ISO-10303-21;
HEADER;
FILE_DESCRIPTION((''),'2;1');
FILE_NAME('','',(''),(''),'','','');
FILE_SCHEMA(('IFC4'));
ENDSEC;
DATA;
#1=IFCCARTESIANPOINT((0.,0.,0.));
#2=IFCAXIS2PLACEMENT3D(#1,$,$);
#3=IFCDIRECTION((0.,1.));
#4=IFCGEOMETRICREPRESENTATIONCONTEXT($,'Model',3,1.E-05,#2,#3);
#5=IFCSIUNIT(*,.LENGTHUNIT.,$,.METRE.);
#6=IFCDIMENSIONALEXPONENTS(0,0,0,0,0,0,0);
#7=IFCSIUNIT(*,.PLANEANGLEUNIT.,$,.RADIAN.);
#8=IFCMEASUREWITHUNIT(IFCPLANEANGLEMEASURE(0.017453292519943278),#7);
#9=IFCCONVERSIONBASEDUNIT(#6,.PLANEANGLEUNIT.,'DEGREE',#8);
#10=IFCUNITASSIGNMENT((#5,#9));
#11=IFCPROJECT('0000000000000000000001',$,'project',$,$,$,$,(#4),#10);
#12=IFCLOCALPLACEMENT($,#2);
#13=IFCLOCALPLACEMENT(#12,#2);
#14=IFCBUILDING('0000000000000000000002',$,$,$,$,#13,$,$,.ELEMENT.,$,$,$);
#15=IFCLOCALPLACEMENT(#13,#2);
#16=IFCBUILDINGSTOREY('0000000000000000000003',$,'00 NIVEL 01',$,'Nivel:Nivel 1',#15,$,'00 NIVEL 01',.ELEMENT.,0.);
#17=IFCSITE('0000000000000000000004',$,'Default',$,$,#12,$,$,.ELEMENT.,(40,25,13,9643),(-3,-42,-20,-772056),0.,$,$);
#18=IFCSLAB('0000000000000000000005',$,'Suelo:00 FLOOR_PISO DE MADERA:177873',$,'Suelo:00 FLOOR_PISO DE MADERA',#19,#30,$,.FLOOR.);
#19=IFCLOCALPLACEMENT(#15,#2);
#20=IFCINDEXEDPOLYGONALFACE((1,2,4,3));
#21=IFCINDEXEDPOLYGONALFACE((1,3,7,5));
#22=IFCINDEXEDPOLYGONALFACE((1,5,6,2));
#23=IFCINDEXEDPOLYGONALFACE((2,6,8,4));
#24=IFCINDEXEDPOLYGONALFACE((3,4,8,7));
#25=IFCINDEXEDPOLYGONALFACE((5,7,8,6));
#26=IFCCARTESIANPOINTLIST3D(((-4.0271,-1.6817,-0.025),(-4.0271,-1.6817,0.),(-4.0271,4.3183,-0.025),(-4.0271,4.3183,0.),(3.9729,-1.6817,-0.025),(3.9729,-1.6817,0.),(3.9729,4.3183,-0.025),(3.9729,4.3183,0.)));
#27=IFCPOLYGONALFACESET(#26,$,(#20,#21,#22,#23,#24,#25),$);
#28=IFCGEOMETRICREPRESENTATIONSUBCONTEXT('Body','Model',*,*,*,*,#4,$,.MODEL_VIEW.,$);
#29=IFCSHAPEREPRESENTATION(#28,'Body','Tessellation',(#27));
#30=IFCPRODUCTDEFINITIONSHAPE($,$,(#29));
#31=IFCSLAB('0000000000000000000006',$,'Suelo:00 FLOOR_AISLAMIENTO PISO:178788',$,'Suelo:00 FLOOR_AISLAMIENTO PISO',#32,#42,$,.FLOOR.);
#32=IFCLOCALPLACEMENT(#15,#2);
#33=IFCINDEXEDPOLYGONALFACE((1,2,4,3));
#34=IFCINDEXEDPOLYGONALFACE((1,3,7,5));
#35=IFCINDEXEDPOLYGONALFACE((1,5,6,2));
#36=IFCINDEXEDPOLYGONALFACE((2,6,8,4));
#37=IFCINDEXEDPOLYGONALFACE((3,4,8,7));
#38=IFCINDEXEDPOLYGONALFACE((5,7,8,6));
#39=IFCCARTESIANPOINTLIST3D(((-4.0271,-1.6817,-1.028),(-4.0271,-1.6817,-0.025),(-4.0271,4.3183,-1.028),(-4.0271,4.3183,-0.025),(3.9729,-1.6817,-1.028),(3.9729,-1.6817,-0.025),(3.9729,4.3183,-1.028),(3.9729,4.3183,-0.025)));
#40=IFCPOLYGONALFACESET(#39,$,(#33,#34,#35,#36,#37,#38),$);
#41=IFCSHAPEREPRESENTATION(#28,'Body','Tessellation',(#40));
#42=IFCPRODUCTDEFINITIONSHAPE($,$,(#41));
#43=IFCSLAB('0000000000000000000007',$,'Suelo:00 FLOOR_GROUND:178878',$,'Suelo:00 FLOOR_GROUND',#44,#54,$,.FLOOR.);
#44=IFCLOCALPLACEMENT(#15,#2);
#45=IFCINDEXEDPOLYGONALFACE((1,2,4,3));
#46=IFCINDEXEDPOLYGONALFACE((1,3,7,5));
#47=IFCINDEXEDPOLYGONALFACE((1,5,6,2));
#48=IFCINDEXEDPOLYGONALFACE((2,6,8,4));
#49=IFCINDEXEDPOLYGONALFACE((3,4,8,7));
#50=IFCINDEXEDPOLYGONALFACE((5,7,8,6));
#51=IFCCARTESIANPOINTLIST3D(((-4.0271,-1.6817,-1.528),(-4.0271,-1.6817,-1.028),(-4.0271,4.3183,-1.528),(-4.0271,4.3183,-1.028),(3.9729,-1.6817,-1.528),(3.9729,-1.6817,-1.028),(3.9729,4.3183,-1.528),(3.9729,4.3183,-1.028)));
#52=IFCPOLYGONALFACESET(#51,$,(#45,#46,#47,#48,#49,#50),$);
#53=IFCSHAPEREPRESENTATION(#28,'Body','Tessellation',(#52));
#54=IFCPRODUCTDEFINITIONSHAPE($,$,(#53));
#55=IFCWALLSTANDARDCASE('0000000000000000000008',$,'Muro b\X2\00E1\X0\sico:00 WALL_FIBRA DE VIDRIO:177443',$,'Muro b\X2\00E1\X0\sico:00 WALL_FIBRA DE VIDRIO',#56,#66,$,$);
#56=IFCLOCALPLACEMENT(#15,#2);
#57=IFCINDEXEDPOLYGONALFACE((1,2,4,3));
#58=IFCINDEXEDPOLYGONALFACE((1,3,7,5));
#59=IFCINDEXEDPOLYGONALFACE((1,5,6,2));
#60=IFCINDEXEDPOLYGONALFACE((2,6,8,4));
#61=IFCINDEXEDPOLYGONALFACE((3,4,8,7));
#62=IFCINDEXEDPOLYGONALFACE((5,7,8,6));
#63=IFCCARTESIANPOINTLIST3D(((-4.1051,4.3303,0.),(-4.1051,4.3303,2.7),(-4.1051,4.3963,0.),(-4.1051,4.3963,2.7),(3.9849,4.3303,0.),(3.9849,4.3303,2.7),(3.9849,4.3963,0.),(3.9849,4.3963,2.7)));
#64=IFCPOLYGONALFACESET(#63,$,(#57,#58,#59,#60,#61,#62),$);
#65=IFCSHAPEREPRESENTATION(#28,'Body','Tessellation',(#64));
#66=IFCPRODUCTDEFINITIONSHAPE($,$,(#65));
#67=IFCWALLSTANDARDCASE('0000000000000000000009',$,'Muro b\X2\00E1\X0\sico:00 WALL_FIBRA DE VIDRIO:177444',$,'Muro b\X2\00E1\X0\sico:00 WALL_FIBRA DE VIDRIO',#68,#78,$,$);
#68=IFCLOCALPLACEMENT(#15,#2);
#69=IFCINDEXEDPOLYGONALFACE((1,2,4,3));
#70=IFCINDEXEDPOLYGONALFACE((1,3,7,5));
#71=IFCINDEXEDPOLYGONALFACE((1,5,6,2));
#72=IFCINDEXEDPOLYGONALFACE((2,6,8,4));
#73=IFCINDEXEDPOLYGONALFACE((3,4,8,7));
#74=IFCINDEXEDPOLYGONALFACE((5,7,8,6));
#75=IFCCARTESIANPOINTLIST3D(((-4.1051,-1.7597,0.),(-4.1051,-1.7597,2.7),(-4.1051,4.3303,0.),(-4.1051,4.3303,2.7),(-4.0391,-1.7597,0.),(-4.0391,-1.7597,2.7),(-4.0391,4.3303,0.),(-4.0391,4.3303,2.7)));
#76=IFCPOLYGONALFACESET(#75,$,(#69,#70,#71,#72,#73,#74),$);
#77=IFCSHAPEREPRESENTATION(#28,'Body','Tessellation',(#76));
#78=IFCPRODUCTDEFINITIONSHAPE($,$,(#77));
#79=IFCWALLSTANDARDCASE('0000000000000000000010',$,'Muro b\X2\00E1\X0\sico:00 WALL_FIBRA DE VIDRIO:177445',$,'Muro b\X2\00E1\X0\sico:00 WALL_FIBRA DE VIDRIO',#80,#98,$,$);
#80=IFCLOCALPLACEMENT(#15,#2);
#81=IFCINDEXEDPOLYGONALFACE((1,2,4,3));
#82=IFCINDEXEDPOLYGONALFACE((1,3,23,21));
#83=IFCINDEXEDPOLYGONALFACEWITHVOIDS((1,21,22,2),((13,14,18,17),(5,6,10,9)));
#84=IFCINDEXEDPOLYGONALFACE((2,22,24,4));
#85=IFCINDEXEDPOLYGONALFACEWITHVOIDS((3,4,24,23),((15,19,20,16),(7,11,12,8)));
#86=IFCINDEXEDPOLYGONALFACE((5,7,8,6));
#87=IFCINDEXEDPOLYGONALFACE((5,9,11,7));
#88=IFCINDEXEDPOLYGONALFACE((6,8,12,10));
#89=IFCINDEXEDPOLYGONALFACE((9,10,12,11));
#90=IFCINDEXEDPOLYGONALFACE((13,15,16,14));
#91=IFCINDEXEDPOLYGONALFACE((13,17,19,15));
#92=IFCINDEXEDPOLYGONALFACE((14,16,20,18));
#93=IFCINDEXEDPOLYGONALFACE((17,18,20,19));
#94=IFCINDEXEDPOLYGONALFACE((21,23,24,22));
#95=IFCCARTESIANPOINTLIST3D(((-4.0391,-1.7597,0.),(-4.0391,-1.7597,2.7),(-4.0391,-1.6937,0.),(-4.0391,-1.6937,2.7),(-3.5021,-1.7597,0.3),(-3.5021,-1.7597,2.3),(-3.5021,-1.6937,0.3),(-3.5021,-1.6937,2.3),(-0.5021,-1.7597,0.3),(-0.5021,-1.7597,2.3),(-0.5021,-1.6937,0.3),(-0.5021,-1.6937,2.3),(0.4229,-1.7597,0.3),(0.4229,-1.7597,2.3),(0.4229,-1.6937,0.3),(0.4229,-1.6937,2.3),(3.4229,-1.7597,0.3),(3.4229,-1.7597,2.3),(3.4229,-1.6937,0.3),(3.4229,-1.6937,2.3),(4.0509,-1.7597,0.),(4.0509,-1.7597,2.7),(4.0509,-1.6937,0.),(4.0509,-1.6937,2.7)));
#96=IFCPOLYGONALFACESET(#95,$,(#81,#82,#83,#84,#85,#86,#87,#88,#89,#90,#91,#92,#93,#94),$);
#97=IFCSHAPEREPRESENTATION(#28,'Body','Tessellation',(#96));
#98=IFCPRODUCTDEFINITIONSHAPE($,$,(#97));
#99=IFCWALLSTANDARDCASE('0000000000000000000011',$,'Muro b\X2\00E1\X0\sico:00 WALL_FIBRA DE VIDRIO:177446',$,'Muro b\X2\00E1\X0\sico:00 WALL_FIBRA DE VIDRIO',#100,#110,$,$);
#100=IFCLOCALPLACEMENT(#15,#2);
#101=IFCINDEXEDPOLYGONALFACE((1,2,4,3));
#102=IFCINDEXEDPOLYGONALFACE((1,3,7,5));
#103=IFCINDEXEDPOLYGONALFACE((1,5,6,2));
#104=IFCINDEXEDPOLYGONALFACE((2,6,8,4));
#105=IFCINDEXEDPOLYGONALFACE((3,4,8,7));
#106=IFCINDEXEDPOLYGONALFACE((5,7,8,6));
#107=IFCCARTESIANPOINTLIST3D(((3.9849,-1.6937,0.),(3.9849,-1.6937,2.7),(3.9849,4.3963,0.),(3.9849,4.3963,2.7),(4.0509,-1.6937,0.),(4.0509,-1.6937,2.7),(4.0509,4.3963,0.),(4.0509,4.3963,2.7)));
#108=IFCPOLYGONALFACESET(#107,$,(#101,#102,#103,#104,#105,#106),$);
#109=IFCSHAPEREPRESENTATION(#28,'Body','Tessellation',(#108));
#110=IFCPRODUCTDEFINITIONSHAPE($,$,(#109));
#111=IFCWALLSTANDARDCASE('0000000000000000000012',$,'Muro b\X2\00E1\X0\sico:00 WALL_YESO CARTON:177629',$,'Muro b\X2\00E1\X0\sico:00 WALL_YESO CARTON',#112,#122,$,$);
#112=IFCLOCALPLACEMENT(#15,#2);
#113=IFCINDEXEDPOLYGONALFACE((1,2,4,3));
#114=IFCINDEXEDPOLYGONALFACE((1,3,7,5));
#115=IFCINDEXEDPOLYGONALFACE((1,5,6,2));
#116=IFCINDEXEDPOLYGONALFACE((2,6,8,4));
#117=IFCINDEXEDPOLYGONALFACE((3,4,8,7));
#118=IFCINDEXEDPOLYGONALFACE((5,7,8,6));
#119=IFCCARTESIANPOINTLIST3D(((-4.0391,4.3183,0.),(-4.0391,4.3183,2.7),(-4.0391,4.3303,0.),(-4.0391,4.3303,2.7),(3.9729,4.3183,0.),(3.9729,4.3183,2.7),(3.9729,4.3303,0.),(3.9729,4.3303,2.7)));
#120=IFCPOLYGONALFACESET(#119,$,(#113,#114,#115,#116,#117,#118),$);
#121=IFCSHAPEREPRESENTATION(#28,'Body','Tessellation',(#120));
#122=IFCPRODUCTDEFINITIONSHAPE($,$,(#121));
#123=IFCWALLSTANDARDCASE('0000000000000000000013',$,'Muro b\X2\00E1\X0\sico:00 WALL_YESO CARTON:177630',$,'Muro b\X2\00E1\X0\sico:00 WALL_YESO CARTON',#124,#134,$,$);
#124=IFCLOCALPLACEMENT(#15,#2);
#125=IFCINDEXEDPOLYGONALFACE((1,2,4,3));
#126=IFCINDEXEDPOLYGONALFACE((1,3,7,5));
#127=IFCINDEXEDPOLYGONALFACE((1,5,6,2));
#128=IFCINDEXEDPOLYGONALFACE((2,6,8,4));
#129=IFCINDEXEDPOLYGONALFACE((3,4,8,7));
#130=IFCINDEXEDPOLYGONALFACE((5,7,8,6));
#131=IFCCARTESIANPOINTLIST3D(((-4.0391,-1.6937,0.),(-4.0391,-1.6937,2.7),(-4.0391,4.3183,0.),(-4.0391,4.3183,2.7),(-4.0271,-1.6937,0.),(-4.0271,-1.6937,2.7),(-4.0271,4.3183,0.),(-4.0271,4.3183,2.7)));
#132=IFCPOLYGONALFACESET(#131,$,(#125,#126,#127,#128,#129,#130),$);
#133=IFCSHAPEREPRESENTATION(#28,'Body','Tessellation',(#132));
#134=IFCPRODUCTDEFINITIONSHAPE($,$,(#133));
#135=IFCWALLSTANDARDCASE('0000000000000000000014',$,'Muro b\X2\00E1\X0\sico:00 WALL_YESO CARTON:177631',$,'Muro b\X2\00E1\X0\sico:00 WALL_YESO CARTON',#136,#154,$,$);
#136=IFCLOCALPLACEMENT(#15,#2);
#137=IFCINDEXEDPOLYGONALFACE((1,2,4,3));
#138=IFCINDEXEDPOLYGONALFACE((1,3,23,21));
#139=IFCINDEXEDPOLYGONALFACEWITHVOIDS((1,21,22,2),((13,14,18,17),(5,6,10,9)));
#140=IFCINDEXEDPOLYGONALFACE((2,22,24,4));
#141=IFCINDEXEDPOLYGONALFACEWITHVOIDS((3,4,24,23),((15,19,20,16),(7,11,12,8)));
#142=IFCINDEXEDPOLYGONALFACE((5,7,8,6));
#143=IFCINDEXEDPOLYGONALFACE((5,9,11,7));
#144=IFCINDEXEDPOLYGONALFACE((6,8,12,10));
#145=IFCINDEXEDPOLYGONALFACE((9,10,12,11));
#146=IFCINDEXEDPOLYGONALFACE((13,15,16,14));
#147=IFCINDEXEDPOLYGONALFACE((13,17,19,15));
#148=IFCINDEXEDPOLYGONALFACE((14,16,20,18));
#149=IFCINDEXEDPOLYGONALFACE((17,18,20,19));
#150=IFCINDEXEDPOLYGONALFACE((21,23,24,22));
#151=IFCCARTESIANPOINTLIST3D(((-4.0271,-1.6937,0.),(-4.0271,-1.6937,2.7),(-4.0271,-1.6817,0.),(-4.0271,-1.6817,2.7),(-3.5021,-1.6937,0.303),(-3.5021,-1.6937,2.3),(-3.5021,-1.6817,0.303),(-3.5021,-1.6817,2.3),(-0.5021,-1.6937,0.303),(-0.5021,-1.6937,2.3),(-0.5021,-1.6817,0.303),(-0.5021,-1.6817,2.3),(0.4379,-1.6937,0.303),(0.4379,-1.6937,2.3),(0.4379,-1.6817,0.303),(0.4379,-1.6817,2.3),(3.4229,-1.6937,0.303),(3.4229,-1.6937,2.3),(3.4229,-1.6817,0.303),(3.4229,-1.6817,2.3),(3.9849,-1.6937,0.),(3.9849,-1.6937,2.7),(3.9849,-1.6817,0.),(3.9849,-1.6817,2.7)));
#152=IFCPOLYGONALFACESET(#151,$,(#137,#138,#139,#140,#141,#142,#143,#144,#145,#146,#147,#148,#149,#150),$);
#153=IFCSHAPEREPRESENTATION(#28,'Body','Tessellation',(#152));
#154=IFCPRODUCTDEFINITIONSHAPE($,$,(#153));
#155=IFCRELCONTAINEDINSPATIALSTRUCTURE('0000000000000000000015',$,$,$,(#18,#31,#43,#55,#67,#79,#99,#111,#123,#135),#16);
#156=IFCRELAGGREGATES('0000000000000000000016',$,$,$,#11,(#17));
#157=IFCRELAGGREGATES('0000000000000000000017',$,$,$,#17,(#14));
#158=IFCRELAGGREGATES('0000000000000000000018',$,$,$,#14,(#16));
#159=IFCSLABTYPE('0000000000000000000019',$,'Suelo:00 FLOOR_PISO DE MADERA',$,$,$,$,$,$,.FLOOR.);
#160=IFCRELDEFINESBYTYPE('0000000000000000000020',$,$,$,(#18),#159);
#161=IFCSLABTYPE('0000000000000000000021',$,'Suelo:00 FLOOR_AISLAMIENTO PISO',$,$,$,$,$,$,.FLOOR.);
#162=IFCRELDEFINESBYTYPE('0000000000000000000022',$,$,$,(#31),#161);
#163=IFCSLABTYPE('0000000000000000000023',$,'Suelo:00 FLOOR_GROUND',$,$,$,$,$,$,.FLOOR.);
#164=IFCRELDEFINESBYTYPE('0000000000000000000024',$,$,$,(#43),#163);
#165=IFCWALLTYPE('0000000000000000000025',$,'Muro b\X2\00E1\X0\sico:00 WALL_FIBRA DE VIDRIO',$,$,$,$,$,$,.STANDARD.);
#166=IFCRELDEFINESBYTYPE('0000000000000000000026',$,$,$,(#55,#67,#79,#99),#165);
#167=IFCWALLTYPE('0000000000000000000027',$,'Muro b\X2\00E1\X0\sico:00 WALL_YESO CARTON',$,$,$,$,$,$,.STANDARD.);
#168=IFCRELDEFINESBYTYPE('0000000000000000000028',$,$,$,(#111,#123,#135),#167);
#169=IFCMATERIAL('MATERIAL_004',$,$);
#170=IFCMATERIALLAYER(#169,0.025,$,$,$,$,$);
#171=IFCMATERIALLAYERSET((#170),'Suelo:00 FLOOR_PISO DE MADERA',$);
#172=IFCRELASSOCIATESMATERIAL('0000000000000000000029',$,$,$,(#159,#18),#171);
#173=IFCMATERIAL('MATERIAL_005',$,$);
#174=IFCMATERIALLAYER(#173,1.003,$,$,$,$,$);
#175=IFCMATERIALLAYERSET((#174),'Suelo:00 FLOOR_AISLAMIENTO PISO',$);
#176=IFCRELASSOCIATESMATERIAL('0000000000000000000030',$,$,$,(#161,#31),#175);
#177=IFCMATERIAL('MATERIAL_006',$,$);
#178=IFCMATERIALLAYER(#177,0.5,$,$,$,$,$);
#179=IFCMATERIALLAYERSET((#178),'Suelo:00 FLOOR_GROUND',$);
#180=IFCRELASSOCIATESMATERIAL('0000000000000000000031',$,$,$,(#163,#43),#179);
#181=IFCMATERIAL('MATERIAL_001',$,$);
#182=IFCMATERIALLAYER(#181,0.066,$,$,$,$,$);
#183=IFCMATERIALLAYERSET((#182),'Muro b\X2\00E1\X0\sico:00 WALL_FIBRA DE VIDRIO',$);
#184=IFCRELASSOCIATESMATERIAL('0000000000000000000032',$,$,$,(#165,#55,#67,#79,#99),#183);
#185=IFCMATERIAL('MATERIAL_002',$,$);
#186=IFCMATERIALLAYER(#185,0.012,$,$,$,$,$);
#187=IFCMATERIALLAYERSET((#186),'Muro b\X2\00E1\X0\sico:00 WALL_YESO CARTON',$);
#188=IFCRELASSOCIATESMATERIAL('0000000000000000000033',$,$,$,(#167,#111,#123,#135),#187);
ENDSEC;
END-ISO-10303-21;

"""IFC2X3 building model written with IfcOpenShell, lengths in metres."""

from ifc_helpers import new_model, entity, si_unit, converted_unit, direction, frame, frame_2d, origin, origin_2d_with_axis, place, context, subcontext, project, spatial, rectangle, extrude, material, layer, layer_set, layer_usage, type_object, element, save


model = new_model("IFC2X3")

# Units and contexts
model_context = context("Model", 3, precision=1e-05, world=origin(), true_north=direction((0.0, 1.0)))
body_context = subcontext(model_context, "Body", "Model", "MODEL_VIEW")
ifc_project = project(units=[si_unit("LENGTHUNIT", "METRE"), converted_unit("PLANEANGLEUNIT", "DEGREE", entity("IfcPlaneAngleMeasure", 0.017453292519943278), si_unit("PLANEANGLEUNIT", "RADIAN"), dimensions=[0, 0, 0, 0, 0, 0, 0])], contexts=[model_context])

# Site, building, storey
site_placement = place(None, origin())
site = spatial("IfcSite", under=ifc_project, at=site_placement, Name="Default", CompositionType="ELEMENT", RefLatitude=(40, 25, 13, 9643), RefLongitude=(-3, -42, -20, -772056), RefElevation=0.0)
building_placement = place(site_placement, origin())
building = spatial("IfcBuilding", under=site, at=building_placement, CompositionType="ELEMENT")
storey_placement = place(building_placement, origin())
storey = spatial("IfcBuildingStorey", under=building, at=storey_placement, Name="00 NIVEL 01", ObjectType="Nivel:Nivel 1", LongName="00 NIVEL 01", CompositionType="ELEMENT", Elevation=0.0)

# Slabs
ifc_material_1 = material(Name="MATERIAL_004")
ifc_layer_1 = layer(ifc_material_1, 0.025)
ifc_layer_set_1 = layer_set([ifc_layer_1], Name="Suelo:00 FLOOR_PISO DE MADERA")
ifc_layer_usage_1 = layer_usage(ifc_layer_set_1, "AXIS3", "POSITIVE", 0.0)
slab_type_1 = type_object("IfcSlabType", Name="Suelo:00 FLOOR_PISO DE MADERA", PredefinedType="FLOOR", material=ifc_layer_set_1)
slab_1_placement = place(storey_placement, origin())
element("IfcSlab", 1, at=slab_1_placement, inside=storey, type_object=slab_type_1, material=ifc_layer_usage_1, Name="Suelo:00 FLOOR_PISO DE MADERA:177873", ObjectType="Suelo:00 FLOOR_PISO DE MADERA", PredefinedType="FLOOR", context=body_context, shape_type="SweptSolid", body=[
    extrude(rectangle(XDim=6.0, YDim=8.0, at=origin_2d_with_axis()), frame((-0.0271, 1.3183, 0.0), z_axis=(0.0, 0.0, -1.0), x_axis=(0.0, 1.0, 0.0)), (0.0, 0.0, 1.0), 0.025),
])
ifc_material_2 = material(Name="MATERIAL_005")
ifc_layer_2 = layer(ifc_material_2, 1.003)
ifc_layer_set_2 = layer_set([ifc_layer_2], Name="Suelo:00 FLOOR_AISLAMIENTO PISO")
ifc_layer_usage_2 = layer_usage(ifc_layer_set_2, "AXIS3", "POSITIVE", 0.0)
slab_type_2 = type_object("IfcSlabType", Name="Suelo:00 FLOOR_AISLAMIENTO PISO", PredefinedType="FLOOR", material=ifc_layer_set_2)
slab_2_placement = place(storey_placement, origin())
element("IfcSlab", 2, at=slab_2_placement, inside=storey, type_object=slab_type_2, material=ifc_layer_usage_2, Name="Suelo:00 FLOOR_AISLAMIENTO PISO:178788", ObjectType="Suelo:00 FLOOR_AISLAMIENTO PISO", PredefinedType="FLOOR", context=body_context, shape_type="SweptSolid", body=[
    extrude(rectangle(XDim=6.0, YDim=8.0, at=origin_2d_with_axis()), frame((-0.0271, 1.3183, -0.025), z_axis=(0.0, 0.0, -1.0), x_axis=(0.0, 1.0, 0.0)), (0.0, 0.0, 1.0), 1.003),
])
ifc_material_3 = material(Name="MATERIAL_006")
ifc_layer_3 = layer(ifc_material_3, 0.5)
ifc_layer_set_3 = layer_set([ifc_layer_3], Name="Suelo:00 FLOOR_GROUND")
ifc_layer_usage_3 = layer_usage(ifc_layer_set_3, "AXIS3", "POSITIVE", 0.0)
slab_type_3 = type_object("IfcSlabType", Name="Suelo:00 FLOOR_GROUND", PredefinedType="FLOOR", material=ifc_layer_set_3)
slab_3_placement = place(storey_placement, origin())
element("IfcSlab", 3, at=slab_3_placement, inside=storey, type_object=slab_type_3, material=ifc_layer_usage_3, Name="Suelo:00 FLOOR_GROUND:178878", ObjectType="Suelo:00 FLOOR_GROUND", PredefinedType="FLOOR", context=body_context, shape_type="SweptSolid", body=[
    extrude(rectangle(XDim=6.0, YDim=8.0, at=origin_2d_with_axis()), frame((-0.0271, 1.3183, -1.028), z_axis=(0.0, 0.0, -1.0), x_axis=(0.0, 1.0, 0.0)), (0.0, 0.0, 1.0), 0.5),
])

# Walls
ifc_material_4 = material(Name="MATERIAL_001")
ifc_layer_4 = layer(ifc_material_4, 0.066)
ifc_layer_set_4 = layer_set([ifc_layer_4], Name="Muro básico:00 WALL_FIBRA DE VIDRIO")
ifc_layer_usage_4 = layer_usage(ifc_layer_set_4, "AXIS2", "NEGATIVE", 0.033)
wall_type_1 = type_object("IfcWallType", Name="Muro básico:00 WALL_FIBRA DE VIDRIO", PredefinedType="STANDARD", material=ifc_layer_set_4)
wall_1_placement = place(storey_placement, frame((-4.1051, 4.3633, 0.0)))
element("IfcWallStandardCase", 4, at=wall_1_placement, inside=storey, type_object=wall_type_1, material=ifc_layer_usage_4, Name="Muro básico:00 WALL_FIBRA DE VIDRIO:177443", ObjectType="Muro básico:00 WALL_FIBRA DE VIDRIO", context=body_context, shape_type="SweptSolid", body=[
    extrude(rectangle(XDim=8.09, YDim=0.066, at=frame_2d((4.045, 0.0), x_axis=(-1.0, 0.0))), origin(), (0.0, 0.0, 1.0), 2.7),
])
ifc_layer_usage_5 = layer_usage(ifc_layer_set_4, "AXIS2", "NEGATIVE", 0.033)
wall_2_placement = place(storey_placement, frame((-4.0721, -1.7597, 0.0), z_axis=(0.0, 0.0, 1.0), x_axis=(0.0, 1.0, 0.0)))
element("IfcWallStandardCase", 5, at=wall_2_placement, inside=storey, type_object=wall_type_1, material=ifc_layer_usage_5, Name="Muro básico:00 WALL_FIBRA DE VIDRIO:177444", ObjectType="Muro básico:00 WALL_FIBRA DE VIDRIO", context=body_context, shape_type="SweptSolid", body=[
    extrude(rectangle(XDim=6.09, YDim=0.066, at=frame_2d((3.045, 0.0), x_axis=(-1.0, 0.0))), origin(), (0.0, 0.0, 1.0), 2.7),
])

# Wall, openings
ifc_layer_usage_6 = layer_usage(ifc_layer_set_4, "AXIS2", "NEGATIVE", 0.033)
wall_3_placement = place(storey_placement, frame((4.0509, -1.7267, 0.0), z_axis=(0.0, 0.0, 1.0), x_axis=(-1.0, 0.0, 0.0)))
wall_3 = element("IfcWallStandardCase", 6, at=wall_3_placement, inside=storey, type_object=wall_type_1, material=ifc_layer_usage_6, Name="Muro básico:00 WALL_FIBRA DE VIDRIO:177445", ObjectType="Muro básico:00 WALL_FIBRA DE VIDRIO", context=body_context, shape_type="SweptSolid", body=[
    extrude(rectangle(XDim=8.09, YDim=0.066, at=frame_2d((4.045, 0.0), x_axis=(-1.0, 0.0))), origin(), (0.0, 0.0, 1.0), 2.7),
])
opening_1_placement = place(wall_3_placement, frame((4.553, -0.033, 0.3)))
element("IfcOpeningElement", 7, at=opening_1_placement, cuts=wall_3, ObjectType="Opening", context=body_context, shape_type="SweptSolid", body=[
    extrude(rectangle(XDim=2.0, YDim=3.0, at=frame_2d((1.0, 1.5), x_axis=(1.0, 0.0))), frame((0.0, 0.0, 0.0), z_axis=(0.0, 1.0, 0.0), x_axis=(0.0, 0.0, 1.0)), (0.0, 0.0, 1.0), 0.066),
])
opening_2_placement = place(wall_3_placement, frame((3.628, 0.033, 0.3)))
element("IfcOpeningElement", 8, at=opening_2_placement, cuts=wall_3, ObjectType="Opening", context=body_context, shape_type="SweptSolid", body=[
    extrude(rectangle(XDim=2.0, YDim=3.0, at=frame_2d((1.0, 1.5), x_axis=(1.0, 0.0))), frame((0.0, 0.0, 0.0), z_axis=(0.0, -1.0, 0.0), x_axis=(0.0, 0.0, 1.0)), (0.0, 0.0, 1.0), 0.066),
])

# Walls
ifc_layer_usage_7 = layer_usage(ifc_layer_set_4, "AXIS2", "NEGATIVE", 0.033)
wall_4_placement = place(storey_placement, frame((4.0179, 4.3963, 0.0), z_axis=(0.0, 0.0, 1.0), x_axis=(0.0, -1.0, 0.0)))
element("IfcWallStandardCase", 9, at=wall_4_placement, inside=storey, type_object=wall_type_1, material=ifc_layer_usage_7, Name="Muro básico:00 WALL_FIBRA DE VIDRIO:177446", ObjectType="Muro básico:00 WALL_FIBRA DE VIDRIO", context=body_context, shape_type="SweptSolid", body=[
    extrude(rectangle(XDim=6.09, YDim=0.066, at=frame_2d((3.045, 0.0), x_axis=(-1.0, 0.0))), origin(), (0.0, 0.0, 1.0), 2.7),
])
ifc_material_5 = material(Name="MATERIAL_002")
ifc_layer_5 = layer(ifc_material_5, 0.012)
ifc_layer_set_5 = layer_set([ifc_layer_5], Name="Muro básico:00 WALL_YESO CARTON")
ifc_layer_usage_8 = layer_usage(ifc_layer_set_5, "AXIS2", "NEGATIVE", 0.006)
wall_type_2 = type_object("IfcWallType", Name="Muro básico:00 WALL_YESO CARTON", PredefinedType="STANDARD", material=ifc_layer_set_5)
wall_5_placement = place(storey_placement, frame((-4.0391, 4.3243, 0.0)))
element("IfcWallStandardCase", 10, at=wall_5_placement, inside=storey, type_object=wall_type_2, material=ifc_layer_usage_8, Name="Muro básico:00 WALL_YESO CARTON:177629", ObjectType="Muro básico:00 WALL_YESO CARTON", context=body_context, shape_type="SweptSolid", body=[
    extrude(rectangle(XDim=8.012, YDim=0.012, at=frame_2d((4.006, 0.0), x_axis=(-1.0, 0.0))), origin(), (0.0, 0.0, 1.0), 2.7),
])
ifc_layer_usage_9 = layer_usage(ifc_layer_set_5, "AXIS2", "NEGATIVE", 0.006)
wall_6_placement = place(storey_placement, frame((-4.0331, -1.6937, 0.0), z_axis=(0.0, 0.0, 1.0), x_axis=(0.0, 1.0, 0.0)))
element("IfcWallStandardCase", 11, at=wall_6_placement, inside=storey, type_object=wall_type_2, material=ifc_layer_usage_9, Name="Muro básico:00 WALL_YESO CARTON:177630", ObjectType="Muro básico:00 WALL_YESO CARTON", context=body_context, shape_type="SweptSolid", body=[
    extrude(rectangle(XDim=6.012, YDim=0.012, at=frame_2d((3.006, 0.0), x_axis=(-1.0, 0.0))), origin(), (0.0, 0.0, 1.0), 2.7),
])

# Wall, openings
ifc_layer_usage_10 = layer_usage(ifc_layer_set_5, "AXIS2", "NEGATIVE", 0.006)
wall_7_placement = place(storey_placement, frame((3.9849, -1.6877, 0.0), z_axis=(0.0, 0.0, 1.0), x_axis=(-1.0, 0.0, 0.0)))
wall_7 = element("IfcWallStandardCase", 12, at=wall_7_placement, inside=storey, type_object=wall_type_2, material=ifc_layer_usage_10, Name="Muro básico:00 WALL_YESO CARTON:177631", ObjectType="Muro básico:00 WALL_YESO CARTON", context=body_context, shape_type="SweptSolid", body=[
    extrude(rectangle(XDim=8.012, YDim=0.012, at=frame_2d((4.006, 0.0), x_axis=(-1.0, 0.0))), origin(), (0.0, 0.0, 1.0), 2.7),
])
opening_3_placement = place(wall_7_placement, origin())
element("IfcOpeningElement", 13, at=opening_3_placement, cuts=wall_7, ObjectType="Opening", context=body_context, shape_type="SweptSolid", body=[
    extrude(rectangle(XDim=1.997, YDim=2.985, at=frame_2d((0.0, 0.0), x_axis=(1.0, 0.0))), frame((2.0545, 0.006, 1.3015), z_axis=(0.0, -1.0, 0.0), x_axis=(0.0, 0.0, 1.0)), (0.0, 0.0, 1.0), 0.012),
])
opening_4_placement = place(wall_7_placement, origin())
element("IfcOpeningElement", 14, at=opening_4_placement, cuts=wall_7, ObjectType="Opening", context=body_context, shape_type="SweptSolid", body=[
    extrude(rectangle(XDim=1.997, YDim=3.0, at=frame_2d((0.0, 0.0), x_axis=(1.0, 0.0))), frame((5.987, 0.006, 1.3015), z_axis=(0.0, -1.0, 0.0), x_axis=(0.0, 0.0, -1.0)), (0.0, 0.0, 1.0), 0.012),
])

save(model, "model.ifc")
